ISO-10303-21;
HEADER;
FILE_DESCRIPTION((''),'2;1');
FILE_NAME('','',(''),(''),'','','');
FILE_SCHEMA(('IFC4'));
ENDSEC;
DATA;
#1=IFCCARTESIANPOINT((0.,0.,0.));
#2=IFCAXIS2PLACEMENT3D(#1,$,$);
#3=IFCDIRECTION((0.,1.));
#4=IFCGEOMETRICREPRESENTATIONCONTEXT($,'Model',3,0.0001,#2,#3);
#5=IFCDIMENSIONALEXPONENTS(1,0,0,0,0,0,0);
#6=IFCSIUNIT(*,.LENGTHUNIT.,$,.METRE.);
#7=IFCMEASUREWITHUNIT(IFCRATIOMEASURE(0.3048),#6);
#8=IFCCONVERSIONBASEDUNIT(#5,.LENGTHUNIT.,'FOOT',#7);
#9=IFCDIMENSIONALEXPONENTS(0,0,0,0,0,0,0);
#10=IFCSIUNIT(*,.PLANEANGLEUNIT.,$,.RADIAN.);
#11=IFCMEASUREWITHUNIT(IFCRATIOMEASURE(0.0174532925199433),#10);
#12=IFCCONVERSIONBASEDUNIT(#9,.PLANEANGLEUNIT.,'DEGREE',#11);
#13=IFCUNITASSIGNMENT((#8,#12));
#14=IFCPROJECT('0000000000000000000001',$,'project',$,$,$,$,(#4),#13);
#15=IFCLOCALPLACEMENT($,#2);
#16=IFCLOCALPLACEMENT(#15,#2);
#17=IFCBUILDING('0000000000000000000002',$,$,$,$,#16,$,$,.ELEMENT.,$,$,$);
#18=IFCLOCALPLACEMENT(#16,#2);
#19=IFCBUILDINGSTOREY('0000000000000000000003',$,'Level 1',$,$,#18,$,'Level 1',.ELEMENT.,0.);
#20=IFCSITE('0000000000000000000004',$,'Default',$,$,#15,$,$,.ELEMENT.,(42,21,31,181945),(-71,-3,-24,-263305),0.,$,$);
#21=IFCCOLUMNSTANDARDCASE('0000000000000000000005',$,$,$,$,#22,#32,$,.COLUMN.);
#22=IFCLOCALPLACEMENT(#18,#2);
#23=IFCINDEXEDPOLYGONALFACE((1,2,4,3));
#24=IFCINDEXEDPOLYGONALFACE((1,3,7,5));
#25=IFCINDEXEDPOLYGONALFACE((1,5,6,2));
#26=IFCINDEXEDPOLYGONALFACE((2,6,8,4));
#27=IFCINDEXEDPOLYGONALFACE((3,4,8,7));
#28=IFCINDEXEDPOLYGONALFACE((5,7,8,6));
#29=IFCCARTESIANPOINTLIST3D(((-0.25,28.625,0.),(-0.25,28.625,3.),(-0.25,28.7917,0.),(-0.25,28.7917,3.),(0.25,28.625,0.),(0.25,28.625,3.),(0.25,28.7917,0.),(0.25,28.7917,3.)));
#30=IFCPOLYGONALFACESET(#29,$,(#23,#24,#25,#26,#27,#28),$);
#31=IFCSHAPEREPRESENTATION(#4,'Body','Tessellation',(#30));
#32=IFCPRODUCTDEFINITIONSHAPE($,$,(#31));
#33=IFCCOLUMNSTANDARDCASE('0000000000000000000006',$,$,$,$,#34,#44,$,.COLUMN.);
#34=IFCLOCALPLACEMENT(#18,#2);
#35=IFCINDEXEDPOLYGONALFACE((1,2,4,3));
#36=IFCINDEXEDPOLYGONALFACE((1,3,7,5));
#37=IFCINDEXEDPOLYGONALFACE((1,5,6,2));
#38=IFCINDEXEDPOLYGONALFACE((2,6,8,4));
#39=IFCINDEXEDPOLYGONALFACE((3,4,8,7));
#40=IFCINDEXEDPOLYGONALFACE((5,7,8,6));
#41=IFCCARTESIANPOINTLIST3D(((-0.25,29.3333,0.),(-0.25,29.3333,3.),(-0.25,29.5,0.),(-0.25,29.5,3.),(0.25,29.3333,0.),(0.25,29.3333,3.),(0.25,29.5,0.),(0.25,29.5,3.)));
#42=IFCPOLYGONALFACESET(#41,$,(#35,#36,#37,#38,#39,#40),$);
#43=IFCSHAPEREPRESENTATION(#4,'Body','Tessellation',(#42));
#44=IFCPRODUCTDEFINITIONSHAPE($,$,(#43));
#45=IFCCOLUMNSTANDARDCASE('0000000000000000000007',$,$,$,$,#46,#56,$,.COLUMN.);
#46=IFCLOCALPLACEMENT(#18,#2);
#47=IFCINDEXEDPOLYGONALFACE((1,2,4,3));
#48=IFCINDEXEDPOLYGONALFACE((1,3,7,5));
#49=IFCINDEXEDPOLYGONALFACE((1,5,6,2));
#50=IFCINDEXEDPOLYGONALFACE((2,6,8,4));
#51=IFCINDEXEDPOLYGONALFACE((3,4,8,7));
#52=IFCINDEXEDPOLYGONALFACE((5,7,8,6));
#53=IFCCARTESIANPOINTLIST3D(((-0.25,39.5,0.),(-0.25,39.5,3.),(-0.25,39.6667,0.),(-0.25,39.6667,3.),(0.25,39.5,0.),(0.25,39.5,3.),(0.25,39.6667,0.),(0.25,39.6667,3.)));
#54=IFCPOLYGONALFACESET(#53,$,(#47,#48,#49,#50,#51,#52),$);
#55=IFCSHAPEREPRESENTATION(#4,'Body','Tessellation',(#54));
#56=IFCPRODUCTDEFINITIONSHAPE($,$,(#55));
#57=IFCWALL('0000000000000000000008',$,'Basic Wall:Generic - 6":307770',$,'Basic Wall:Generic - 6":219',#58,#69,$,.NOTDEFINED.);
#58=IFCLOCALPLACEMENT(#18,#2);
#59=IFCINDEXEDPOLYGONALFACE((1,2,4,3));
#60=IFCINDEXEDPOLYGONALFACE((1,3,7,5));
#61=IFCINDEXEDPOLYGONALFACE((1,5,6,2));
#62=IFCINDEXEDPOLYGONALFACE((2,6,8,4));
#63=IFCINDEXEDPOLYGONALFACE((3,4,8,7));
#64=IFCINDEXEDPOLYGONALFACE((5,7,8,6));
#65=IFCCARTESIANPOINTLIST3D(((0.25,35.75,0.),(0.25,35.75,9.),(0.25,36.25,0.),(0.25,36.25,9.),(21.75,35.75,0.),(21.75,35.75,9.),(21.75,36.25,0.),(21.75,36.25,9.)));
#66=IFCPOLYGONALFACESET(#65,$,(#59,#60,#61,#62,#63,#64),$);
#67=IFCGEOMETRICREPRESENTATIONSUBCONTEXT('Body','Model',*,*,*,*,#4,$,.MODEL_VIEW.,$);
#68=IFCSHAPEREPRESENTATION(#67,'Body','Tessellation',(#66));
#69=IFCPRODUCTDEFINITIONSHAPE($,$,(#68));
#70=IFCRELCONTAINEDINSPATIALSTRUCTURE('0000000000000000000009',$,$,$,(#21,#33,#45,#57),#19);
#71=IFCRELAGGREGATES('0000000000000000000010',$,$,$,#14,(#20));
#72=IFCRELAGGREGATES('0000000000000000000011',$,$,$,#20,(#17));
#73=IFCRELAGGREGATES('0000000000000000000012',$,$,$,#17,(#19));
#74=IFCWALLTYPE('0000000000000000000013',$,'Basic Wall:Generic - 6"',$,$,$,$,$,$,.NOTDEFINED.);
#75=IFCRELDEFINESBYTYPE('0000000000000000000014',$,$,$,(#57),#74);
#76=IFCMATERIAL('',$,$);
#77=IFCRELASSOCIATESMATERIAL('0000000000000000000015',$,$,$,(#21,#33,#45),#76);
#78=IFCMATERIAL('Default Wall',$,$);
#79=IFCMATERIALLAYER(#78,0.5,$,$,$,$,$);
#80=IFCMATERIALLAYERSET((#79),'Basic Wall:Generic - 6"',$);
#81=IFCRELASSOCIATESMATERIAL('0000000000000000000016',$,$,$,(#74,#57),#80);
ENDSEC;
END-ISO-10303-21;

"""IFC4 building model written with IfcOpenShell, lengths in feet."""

from ifc_helpers import new_model, entity, si_unit, converted_unit, direction, frame, frame_2d, origin, place, context, subcontext, project, spatial, polyline, rectangle, extrude, clip, bounded_halfspace, material, layer, layer_set, layer_usage, type_object, element, save


model = new_model("IFC4")

# Units and contexts
model_context = context("Model", 3, precision=0.0001, world=origin(), true_north=direction((0.0, 1.0)))
body_context = subcontext(model_context, "Body", "Model", "MODEL_VIEW")
ifc_project = project(units=[converted_unit("LENGTHUNIT", "FOOT", entity("IfcRatioMeasure", 0.3048), si_unit("LENGTHUNIT", "METRE"), dimensions=[1, 0, 0, 0, 0, 0, 0]), converted_unit("PLANEANGLEUNIT", "DEGREE", entity("IfcRatioMeasure", 0.0174532925199433), si_unit("PLANEANGLEUNIT", "RADIAN"), dimensions=[0, 0, 0, 0, 0, 0, 0])], contexts=[model_context])

# Site, building, storey
site_placement = place(None, origin())
site = spatial("IfcSite", under=ifc_project, at=site_placement, Name="Default", CompositionType="ELEMENT", RefLatitude=(42, 21, 31, 181945), RefLongitude=(-71, -3, -24, -263305), RefElevation=0.0)
building_placement = place(site_placement, origin())
building = spatial("IfcBuilding", under=site, at=building_placement, CompositionType="ELEMENT")
storey_placement = place(building_placement, origin())
storey = spatial("IfcBuildingStorey", under=building, at=storey_placement, Name="Level 1", LongName="Level 1", CompositionType="ELEMENT", Elevation=0.0)

# Columns
placement = place(storey_placement, frame((0.0, -0.25, 0.0), z_axis=(0.0, 0.0, 1.0), x_axis=(0.0, 1.0, 0.0)))
ifc_material_1 = material(Name="")
for number, where, z_axis, x_axis in (
    (1, (28.9583, 0.0, 0.0), (0.0, 0.0, 1.0), (1.0, 0.0, 0.0)),
    (2, (29.6667, 0.0, 0.0), (0.0, 0.0, 1.0), (1.0, 0.0, 0.0)),
    (3, (39.8334, 0.0, 0.0), (0.0, 0.0, 1.0), (1.0, 0.0, 0.0)),
):
    element("IfcColumnStandardCase", number, at=place(placement, frame(where, z_axis=z_axis, x_axis=x_axis)), inside=storey, material=ifc_material_1, PredefinedType="COLUMN", context=model_context, shape_type="SweptSolid", body=[
        extrude(rectangle(XDim=0.1667, YDim=0.5), origin(), (0.0, 0.0, 1.0), 3.0),
    ])

# Wall
ifc_material_2 = material(Name="Default Wall")
ifc_layer = layer(ifc_material_2, 0.5)
ifc_layer_set = layer_set([ifc_layer], Name="Basic Wall:Generic - 6\"")
ifc_layer_usage = layer_usage(ifc_layer_set, "AXIS2", "NEGATIVE", 0.25)
wall_type = type_object("IfcWallType", Name="Basic Wall:Generic - 6\"", PredefinedType="NOTDEFINED", material=ifc_layer_set)
wall_placement = place(storey_placement, frame((0.25, 36.0, 0.0)))
element("IfcWall", 4, at=wall_placement, inside=storey, type_object=wall_type, material=ifc_layer_usage, Name="Basic Wall:Generic - 6\":307770", ObjectType="Basic Wall:Generic - 6\":219", PredefinedType="NOTDEFINED", context=body_context, shape_type="Clipping", body=[
    clip(extrude(rectangle(XDim=21.5, YDim=0.5, at=frame_2d((10.75, 0.0), x_axis=(-1.0, 0.0))), origin(), (0.0, 0.0, 1.0), 9.0), bounded_halfspace(frame((0.0, -0.25, 9.0), z_axis=(0.0, 0.0, -1.0), x_axis=(-1.0, 0.0, 0.0)), True, frame((0.0, -0.25, 9.0)), polyline([(0.0, 0.0), (21.5, 0.0), (21.5, 0.5), (0.0, 0.5), (0.0, 0.0)]))),
])

save(model, "model.ifc")
